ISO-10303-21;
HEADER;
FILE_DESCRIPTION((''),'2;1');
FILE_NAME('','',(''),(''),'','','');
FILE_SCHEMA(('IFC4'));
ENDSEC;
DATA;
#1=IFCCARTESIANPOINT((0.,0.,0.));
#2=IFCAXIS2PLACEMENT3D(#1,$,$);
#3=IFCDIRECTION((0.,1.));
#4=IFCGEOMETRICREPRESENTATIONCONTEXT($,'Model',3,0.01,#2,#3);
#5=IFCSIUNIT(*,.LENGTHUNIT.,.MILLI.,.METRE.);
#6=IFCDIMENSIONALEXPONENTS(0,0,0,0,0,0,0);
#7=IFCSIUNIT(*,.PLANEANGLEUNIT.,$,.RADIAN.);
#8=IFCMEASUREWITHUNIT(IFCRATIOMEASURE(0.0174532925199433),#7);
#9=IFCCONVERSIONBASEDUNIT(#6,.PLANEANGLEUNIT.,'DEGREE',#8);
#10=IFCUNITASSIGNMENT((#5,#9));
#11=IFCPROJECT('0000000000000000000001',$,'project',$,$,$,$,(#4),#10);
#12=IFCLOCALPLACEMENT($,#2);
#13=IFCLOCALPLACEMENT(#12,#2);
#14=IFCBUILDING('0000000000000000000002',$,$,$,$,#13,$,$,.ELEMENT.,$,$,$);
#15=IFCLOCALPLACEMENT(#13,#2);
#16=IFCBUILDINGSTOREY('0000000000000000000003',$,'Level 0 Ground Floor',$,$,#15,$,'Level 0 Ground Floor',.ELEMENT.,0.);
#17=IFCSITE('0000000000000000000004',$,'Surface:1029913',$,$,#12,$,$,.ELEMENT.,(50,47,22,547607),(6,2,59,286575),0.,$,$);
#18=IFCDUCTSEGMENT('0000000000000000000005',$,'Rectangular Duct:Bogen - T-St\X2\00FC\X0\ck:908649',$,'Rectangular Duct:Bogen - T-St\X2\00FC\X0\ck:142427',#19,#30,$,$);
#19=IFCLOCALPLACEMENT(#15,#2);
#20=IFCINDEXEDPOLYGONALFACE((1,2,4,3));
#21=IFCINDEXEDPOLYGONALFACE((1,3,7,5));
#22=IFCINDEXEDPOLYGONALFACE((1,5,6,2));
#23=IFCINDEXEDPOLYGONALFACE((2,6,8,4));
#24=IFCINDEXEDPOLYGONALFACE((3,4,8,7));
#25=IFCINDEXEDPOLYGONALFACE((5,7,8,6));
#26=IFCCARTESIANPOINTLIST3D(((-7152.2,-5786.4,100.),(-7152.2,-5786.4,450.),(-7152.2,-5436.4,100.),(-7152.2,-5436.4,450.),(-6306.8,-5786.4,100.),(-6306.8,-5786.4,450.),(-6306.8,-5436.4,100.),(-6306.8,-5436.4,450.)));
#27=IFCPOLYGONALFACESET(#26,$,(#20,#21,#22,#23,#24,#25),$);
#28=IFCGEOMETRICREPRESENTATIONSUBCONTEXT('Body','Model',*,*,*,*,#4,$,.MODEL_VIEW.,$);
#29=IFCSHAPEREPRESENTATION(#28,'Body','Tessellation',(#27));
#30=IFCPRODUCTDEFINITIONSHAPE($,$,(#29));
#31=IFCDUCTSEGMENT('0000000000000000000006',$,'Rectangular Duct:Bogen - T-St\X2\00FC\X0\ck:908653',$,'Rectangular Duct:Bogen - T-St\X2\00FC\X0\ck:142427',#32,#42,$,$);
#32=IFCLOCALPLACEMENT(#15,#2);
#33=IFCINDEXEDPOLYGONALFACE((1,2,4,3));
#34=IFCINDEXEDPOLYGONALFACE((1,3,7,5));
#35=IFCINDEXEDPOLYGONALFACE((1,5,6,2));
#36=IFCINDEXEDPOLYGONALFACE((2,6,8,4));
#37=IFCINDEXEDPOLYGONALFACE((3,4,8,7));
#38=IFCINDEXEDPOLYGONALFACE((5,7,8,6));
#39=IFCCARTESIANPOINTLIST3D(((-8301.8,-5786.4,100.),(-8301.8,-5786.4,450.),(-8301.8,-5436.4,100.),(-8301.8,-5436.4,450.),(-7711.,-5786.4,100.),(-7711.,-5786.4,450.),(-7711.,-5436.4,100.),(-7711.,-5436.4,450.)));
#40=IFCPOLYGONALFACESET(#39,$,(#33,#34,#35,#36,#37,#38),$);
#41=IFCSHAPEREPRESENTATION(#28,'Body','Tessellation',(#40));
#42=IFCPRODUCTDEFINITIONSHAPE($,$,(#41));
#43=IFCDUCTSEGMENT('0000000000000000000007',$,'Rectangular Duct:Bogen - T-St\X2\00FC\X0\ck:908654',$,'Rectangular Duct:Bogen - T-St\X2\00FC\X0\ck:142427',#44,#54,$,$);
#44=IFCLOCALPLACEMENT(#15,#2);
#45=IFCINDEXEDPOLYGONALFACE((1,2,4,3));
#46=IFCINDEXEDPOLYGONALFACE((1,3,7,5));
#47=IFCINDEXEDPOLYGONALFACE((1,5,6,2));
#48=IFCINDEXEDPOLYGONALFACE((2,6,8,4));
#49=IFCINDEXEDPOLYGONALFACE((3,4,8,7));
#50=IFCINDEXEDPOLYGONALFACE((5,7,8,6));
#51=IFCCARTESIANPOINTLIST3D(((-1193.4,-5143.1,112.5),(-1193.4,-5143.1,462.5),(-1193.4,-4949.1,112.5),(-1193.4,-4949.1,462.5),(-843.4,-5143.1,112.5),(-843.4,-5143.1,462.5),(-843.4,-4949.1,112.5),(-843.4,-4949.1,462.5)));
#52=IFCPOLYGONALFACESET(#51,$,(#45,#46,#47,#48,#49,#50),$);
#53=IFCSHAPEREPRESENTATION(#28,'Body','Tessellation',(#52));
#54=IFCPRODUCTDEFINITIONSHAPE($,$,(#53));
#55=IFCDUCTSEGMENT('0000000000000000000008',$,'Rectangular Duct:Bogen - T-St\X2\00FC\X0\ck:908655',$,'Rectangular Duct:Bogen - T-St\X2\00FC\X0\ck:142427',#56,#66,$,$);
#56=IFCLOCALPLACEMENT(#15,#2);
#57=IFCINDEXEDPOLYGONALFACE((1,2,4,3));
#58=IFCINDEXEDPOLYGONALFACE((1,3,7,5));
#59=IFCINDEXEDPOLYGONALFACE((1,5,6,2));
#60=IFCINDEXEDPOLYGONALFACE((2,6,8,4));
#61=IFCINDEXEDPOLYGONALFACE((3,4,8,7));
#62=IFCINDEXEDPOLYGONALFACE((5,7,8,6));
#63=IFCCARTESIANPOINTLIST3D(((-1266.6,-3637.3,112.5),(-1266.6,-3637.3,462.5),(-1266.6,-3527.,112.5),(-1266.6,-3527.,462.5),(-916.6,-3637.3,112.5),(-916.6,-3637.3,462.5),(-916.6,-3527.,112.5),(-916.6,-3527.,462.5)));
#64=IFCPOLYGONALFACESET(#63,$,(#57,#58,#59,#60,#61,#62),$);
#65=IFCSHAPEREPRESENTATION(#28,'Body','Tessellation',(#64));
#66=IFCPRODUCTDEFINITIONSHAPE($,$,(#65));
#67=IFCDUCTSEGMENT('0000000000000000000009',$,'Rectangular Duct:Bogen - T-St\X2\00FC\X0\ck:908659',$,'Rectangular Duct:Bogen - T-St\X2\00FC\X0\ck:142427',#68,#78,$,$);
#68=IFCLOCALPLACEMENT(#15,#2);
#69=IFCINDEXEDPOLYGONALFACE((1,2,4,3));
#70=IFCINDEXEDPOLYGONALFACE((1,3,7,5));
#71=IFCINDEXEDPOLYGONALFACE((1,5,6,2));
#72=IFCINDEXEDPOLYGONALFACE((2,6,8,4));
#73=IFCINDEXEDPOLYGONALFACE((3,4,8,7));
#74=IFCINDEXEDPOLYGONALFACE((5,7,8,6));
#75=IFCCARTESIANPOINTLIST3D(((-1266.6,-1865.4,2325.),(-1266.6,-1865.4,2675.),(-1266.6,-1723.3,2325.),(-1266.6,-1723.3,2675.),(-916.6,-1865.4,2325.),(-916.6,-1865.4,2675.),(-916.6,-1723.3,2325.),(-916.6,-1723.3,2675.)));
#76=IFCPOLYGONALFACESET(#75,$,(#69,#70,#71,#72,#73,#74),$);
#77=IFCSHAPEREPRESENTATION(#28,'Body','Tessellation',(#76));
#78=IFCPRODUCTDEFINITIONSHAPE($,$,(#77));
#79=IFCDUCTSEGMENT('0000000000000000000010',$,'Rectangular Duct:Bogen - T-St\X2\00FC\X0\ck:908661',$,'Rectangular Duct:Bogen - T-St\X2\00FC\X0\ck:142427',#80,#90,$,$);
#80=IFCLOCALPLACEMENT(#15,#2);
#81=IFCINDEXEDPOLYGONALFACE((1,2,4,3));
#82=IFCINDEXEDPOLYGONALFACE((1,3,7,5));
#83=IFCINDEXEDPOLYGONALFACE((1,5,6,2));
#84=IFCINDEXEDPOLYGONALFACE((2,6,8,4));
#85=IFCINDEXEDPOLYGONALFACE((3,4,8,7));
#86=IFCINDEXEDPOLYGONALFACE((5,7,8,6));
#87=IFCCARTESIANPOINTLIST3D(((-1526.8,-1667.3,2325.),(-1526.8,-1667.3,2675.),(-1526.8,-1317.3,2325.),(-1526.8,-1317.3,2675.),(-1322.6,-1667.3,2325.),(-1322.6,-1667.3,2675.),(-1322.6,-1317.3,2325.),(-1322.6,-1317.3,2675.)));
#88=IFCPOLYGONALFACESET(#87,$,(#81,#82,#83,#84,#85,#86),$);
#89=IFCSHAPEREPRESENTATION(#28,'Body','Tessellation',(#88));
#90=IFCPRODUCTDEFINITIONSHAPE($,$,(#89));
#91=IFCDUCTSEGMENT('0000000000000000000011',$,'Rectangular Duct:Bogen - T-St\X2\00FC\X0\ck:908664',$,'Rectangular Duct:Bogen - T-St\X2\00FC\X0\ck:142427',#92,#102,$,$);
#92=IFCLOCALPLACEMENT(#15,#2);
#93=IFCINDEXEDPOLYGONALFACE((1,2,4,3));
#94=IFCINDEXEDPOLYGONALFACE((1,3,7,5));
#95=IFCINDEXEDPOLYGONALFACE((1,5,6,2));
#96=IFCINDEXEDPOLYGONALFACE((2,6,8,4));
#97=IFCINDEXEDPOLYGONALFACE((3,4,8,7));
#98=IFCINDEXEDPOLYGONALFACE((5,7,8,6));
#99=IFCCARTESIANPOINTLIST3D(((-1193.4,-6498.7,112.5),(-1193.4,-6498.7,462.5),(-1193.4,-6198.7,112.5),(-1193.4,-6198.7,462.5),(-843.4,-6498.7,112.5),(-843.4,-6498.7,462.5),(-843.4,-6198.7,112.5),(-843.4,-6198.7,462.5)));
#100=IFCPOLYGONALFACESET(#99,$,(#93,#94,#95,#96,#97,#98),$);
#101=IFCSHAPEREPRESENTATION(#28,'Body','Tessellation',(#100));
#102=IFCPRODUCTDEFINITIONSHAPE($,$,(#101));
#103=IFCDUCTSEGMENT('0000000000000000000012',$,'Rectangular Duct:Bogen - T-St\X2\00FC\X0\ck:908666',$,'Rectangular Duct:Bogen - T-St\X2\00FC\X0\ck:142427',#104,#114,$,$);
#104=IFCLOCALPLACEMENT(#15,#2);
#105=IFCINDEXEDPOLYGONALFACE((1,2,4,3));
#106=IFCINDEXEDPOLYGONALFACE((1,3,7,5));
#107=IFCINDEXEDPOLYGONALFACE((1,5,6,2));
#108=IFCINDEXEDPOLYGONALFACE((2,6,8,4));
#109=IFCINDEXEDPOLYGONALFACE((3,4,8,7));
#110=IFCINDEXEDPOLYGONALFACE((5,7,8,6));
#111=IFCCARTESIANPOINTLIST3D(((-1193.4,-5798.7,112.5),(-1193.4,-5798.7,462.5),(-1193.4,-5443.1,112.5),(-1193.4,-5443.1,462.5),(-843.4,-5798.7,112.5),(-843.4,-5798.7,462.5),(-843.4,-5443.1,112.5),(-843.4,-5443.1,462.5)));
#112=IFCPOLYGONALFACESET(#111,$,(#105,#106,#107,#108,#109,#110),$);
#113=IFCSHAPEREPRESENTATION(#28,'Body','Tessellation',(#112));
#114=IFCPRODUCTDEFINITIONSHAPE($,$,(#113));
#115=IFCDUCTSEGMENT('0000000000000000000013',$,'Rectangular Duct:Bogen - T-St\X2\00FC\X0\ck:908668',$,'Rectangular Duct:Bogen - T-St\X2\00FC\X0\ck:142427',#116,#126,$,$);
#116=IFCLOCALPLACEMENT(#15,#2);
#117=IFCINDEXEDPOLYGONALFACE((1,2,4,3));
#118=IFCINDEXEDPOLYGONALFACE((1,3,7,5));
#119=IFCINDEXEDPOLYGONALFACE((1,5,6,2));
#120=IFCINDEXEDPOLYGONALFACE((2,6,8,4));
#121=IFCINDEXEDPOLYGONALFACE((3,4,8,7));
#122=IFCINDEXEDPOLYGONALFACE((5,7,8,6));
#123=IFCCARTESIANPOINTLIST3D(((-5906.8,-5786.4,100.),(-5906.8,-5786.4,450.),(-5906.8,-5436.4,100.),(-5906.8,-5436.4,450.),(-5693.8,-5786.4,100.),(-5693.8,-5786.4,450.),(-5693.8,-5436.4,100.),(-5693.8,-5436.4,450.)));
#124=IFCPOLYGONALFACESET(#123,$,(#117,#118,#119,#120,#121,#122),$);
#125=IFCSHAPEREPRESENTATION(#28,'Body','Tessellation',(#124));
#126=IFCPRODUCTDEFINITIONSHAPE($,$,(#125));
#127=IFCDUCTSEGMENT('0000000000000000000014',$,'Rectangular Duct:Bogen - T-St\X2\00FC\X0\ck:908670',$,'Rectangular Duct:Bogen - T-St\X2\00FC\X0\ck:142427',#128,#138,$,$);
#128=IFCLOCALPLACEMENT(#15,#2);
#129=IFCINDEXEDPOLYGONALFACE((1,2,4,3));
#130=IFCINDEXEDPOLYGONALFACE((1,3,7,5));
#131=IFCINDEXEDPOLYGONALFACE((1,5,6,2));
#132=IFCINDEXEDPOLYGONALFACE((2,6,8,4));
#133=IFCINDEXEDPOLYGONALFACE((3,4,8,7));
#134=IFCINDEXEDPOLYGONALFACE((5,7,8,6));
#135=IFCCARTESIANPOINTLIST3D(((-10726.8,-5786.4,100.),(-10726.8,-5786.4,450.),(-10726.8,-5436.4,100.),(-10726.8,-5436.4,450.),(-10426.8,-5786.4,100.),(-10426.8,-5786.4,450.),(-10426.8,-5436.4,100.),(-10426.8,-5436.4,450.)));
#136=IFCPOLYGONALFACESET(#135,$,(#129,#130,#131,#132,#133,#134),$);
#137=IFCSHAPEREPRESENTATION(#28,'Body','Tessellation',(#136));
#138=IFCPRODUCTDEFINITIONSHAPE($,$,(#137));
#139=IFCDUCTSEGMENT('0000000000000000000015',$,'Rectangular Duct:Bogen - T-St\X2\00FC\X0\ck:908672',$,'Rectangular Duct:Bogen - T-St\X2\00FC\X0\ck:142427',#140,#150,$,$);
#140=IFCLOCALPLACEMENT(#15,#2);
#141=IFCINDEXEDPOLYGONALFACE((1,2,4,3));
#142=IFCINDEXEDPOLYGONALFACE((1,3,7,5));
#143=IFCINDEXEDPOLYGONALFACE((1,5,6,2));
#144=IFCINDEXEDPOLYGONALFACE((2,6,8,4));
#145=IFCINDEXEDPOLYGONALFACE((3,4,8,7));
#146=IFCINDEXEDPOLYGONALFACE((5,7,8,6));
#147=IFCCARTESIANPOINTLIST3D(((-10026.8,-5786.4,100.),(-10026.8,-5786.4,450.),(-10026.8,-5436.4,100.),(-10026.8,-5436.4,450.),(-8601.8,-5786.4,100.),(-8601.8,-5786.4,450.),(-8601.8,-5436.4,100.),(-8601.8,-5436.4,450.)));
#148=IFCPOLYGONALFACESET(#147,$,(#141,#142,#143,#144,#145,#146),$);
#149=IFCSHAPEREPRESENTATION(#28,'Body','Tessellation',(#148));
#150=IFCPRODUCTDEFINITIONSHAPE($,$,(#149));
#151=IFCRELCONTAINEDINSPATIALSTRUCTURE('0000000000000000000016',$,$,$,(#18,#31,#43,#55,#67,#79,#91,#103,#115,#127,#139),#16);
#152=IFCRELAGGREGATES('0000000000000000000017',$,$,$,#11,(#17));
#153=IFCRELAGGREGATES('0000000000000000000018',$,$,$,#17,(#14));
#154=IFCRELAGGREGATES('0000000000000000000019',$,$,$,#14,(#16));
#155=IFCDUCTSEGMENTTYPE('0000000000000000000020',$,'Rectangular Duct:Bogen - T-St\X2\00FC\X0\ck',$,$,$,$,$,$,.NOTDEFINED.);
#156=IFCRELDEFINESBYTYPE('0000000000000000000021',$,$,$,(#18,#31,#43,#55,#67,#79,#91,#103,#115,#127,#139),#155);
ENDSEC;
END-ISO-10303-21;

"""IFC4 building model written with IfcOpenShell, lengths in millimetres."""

from ifc_helpers import new_model, entity, si_unit, converted_unit, direction, frame, frame_2d, origin, origin_2d_with_axis, place, context, subcontext, project, spatial, rectangle, extrude, type_object, element, save


model = new_model("IFC4")

# Units and contexts
model_context = context("Model", 3, precision=0.01, world=origin(), true_north=direction((0.0, 1.0)))
body_context = subcontext(model_context, "Body", "Model", "MODEL_VIEW")
ifc_project = project(units=[si_unit("LENGTHUNIT", "METRE", prefix="MILLI"), converted_unit("PLANEANGLEUNIT", "DEGREE", entity("IfcRatioMeasure", 0.0174532925199433), si_unit("PLANEANGLEUNIT", "RADIAN"), dimensions=[0, 0, 0, 0, 0, 0, 0])], contexts=[model_context])

# Site, building, storey
site_placement = place(None, origin())
site = spatial("IfcSite", under=ifc_project, at=site_placement, Name="Surface:1029913", CompositionType="ELEMENT", RefLatitude=(50, 47, 22, 547607), RefLongitude=(6, 2, 59, 286575), RefElevation=0.0)
building_placement = place(site_placement, origin())
building = spatial("IfcBuilding", under=site, at=building_placement, CompositionType="ELEMENT")
storey_placement = place(building_placement, origin())
storey = spatial("IfcBuildingStorey", under=building, at=storey_placement, Name="Level 0 Ground Floor", LongName="Level 0 Ground Floor", CompositionType="ELEMENT", Elevation=0.0)

# Duct segments
duct_segment_type = type_object("IfcDuctSegmentType", Name="Rectangular Duct:Bogen - T-Stück", PredefinedType="NOTDEFINED")
duct_segment_1_placement = place(storey_placement, frame((-7152.2, -5786.4, 100.0)))
element("IfcDuctSegment", 1, at=duct_segment_1_placement, inside=storey, type_object=duct_segment_type, Name="Rectangular Duct:Bogen - T-Stück:908649", ObjectType="Rectangular Duct:Bogen - T-Stück:142427", context=body_context, shape_type="SweptSolid", body=[
    extrude(rectangle(XDim=845.4, YDim=350.0, at=frame_2d((0.0, 0.0), x_axis=(1.0, 0.0))), frame((422.7, 175.0, 0.0), z_axis=(0.0, 0.0, 1.0), x_axis=(-1.0, 0.0, 0.0)), (0.0, 0.0, 1.0), 350.0),
])
duct_segment_2_placement = place(storey_placement, frame((-8301.8, -5786.4, 100.0)))
element("IfcDuctSegment", 2, at=duct_segment_2_placement, inside=storey, type_object=duct_segment_type, Name="Rectangular Duct:Bogen - T-Stück:908653", ObjectType="Rectangular Duct:Bogen - T-Stück:142427", context=body_context, shape_type="SweptSolid", body=[
    extrude(rectangle(XDim=590.8, YDim=350.0, at=origin_2d_with_axis()), frame((295.4, 175.0, 0.0)), (0.0, 0.0, 1.0), 350.0),
])
duct_segment_3_placement = place(storey_placement, frame((-1193.4, -5143.1, 112.5)))
element("IfcDuctSegment", 3, at=duct_segment_3_placement, inside=storey, type_object=duct_segment_type, Name="Rectangular Duct:Bogen - T-Stück:908654", ObjectType="Rectangular Duct:Bogen - T-Stück:142427", context=body_context, shape_type="SweptSolid", body=[
    extrude(rectangle(XDim=194.0, YDim=350.0, at=frame_2d((0.0, 0.0), x_axis=(1.0, 0.0))), frame((175.0, 97.0, 0.0), z_axis=(0.0, 0.0, 1.0), x_axis=(0.0, 1.0, 0.0)), (0.0, 0.0, 1.0), 350.0),
])
duct_segment_4_placement = place(storey_placement, frame((-1266.6, -3637.3, 112.5)))
element("IfcDuctSegment", 4, at=duct_segment_4_placement, inside=storey, type_object=duct_segment_type, Name="Rectangular Duct:Bogen - T-Stück:908655", ObjectType="Rectangular Duct:Bogen - T-Stück:142427", context=body_context, shape_type="SweptSolid", body=[
    extrude(rectangle(XDim=110.2, YDim=350.0, at=frame_2d((0.0, 0.0), x_axis=(1.0, 0.0))), frame((175.0, 55.1, 0.0), z_axis=(0.0, 0.0, 1.0), x_axis=(0.0, 1.0, 0.0)), (0.0, 0.0, 1.0), 350.0),
])
duct_segment_5_placement = place(storey_placement, frame((-1266.6, -1865.4, 2325.0)))
element("IfcDuctSegment", 5, at=duct_segment_5_placement, inside=storey, type_object=duct_segment_type, Name="Rectangular Duct:Bogen - T-Stück:908659", ObjectType="Rectangular Duct:Bogen - T-Stück:142427", context=body_context, shape_type="SweptSolid", body=[
    extrude(rectangle(XDim=142.1, YDim=350.0, at=origin_2d_with_axis()), frame((175.0, 71.0, 0.0), z_axis=(0.0, 0.0, 1.0), x_axis=(0.0, -1.0, 0.0)), (0.0, 0.0, 1.0), 350.0),
])
duct_segment_6_placement = place(storey_placement, frame((-1526.8, -1667.3, 2325.0)))
element("IfcDuctSegment", 6, at=duct_segment_6_placement, inside=storey, type_object=duct_segment_type, Name="Rectangular Duct:Bogen - T-Stück:908661", ObjectType="Rectangular Duct:Bogen - T-Stück:142427", context=body_context, shape_type="SweptSolid", body=[
    extrude(rectangle(XDim=204.2, YDim=350.0, at=frame_2d((0.0, 0.0), x_axis=(1.0, 0.0))), frame((102.1, 175.0, 0.0), z_axis=(0.0, 0.0, 1.0), x_axis=(-1.0, 0.0, 0.0)), (0.0, 0.0, 1.0), 350.0),
])
duct_segment_7_placement = place(storey_placement, frame((-1193.4, -6498.7, 112.5)))
element("IfcDuctSegment", 7, at=duct_segment_7_placement, inside=storey, type_object=duct_segment_type, Name="Rectangular Duct:Bogen - T-Stück:908664", ObjectType="Rectangular Duct:Bogen - T-Stück:142427", context=body_context, shape_type="SweptSolid", body=[
    extrude(rectangle(XDim=300.0, YDim=350.0, at=frame_2d((0.0, 0.0), x_axis=(1.0, 0.0))), frame((175.0, 150.0, 0.0), z_axis=(0.0, 0.0, 1.0), x_axis=(0.0, 1.0, 0.0)), (0.0, 0.0, 1.0), 350.0),
])
duct_segment_8_placement = place(storey_placement, frame((-1193.4, -5798.7, 112.5)))
element("IfcDuctSegment", 8, at=duct_segment_8_placement, inside=storey, type_object=duct_segment_type, Name="Rectangular Duct:Bogen - T-Stück:908666", ObjectType="Rectangular Duct:Bogen - T-Stück:142427", context=body_context, shape_type="SweptSolid", body=[
    extrude(rectangle(XDim=355.6, YDim=350.0, at=frame_2d((0.0, 0.0), x_axis=(1.0, 0.0))), frame((175.0, 177.8, 0.0), z_axis=(0.0, 0.0, 1.0), x_axis=(0.0, 1.0, 0.0)), (0.0, 0.0, 1.0), 350.0),
])
duct_segment_9_placement = place(storey_placement, frame((-5906.8, -5786.4, 100.0)))
element("IfcDuctSegment", 9, at=duct_segment_9_placement, inside=storey, type_object=duct_segment_type, Name="Rectangular Duct:Bogen - T-Stück:908668", ObjectType="Rectangular Duct:Bogen - T-Stück:142427", context=body_context, shape_type="SweptSolid", body=[
    extrude(rectangle(XDim=213.0, YDim=350.0, at=frame_2d((0.0, 0.0), x_axis=(1.0, 0.0))), frame((106.5, 175.0, 0.0), z_axis=(0.0, 0.0, 1.0), x_axis=(-1.0, 0.0, 0.0)), (0.0, 0.0, 1.0), 350.0),
])
duct_segment_10_placement = place(storey_placement, frame((-10726.8, -5786.4, 100.0)))
element("IfcDuctSegment", 10, at=duct_segment_10_placement, inside=storey, type_object=duct_segment_type, Name="Rectangular Duct:Bogen - T-Stück:908670", ObjectType="Rectangular Duct:Bogen - T-Stück:142427", context=body_context, shape_type="SweptSolid", body=[
    extrude(rectangle(XDim=300.0, YDim=350.0, at=frame_2d((0.0, 0.0), x_axis=(1.0, 0.0))), frame((150.0, 175.0, 0.0)), (0.0, 0.0, 1.0), 350.0),
])
duct_segment_11_placement = place(storey_placement, frame((-10026.8, -5786.4, 100.0)))
element("IfcDuctSegment", 11, at=duct_segment_11_placement, inside=storey, type_object=duct_segment_type, Name="Rectangular Duct:Bogen - T-Stück:908672", ObjectType="Rectangular Duct:Bogen - T-Stück:142427", context=body_context, shape_type="SweptSolid", body=[
    extrude(rectangle(XDim=1425.0, YDim=350.0, at=frame_2d((0.0, 0.0), x_axis=(1.0, 0.0))), frame((712.5, 175.0, 0.0)), (0.0, 0.0, 1.0), 350.0),
])

save(model, "model.ifc")
